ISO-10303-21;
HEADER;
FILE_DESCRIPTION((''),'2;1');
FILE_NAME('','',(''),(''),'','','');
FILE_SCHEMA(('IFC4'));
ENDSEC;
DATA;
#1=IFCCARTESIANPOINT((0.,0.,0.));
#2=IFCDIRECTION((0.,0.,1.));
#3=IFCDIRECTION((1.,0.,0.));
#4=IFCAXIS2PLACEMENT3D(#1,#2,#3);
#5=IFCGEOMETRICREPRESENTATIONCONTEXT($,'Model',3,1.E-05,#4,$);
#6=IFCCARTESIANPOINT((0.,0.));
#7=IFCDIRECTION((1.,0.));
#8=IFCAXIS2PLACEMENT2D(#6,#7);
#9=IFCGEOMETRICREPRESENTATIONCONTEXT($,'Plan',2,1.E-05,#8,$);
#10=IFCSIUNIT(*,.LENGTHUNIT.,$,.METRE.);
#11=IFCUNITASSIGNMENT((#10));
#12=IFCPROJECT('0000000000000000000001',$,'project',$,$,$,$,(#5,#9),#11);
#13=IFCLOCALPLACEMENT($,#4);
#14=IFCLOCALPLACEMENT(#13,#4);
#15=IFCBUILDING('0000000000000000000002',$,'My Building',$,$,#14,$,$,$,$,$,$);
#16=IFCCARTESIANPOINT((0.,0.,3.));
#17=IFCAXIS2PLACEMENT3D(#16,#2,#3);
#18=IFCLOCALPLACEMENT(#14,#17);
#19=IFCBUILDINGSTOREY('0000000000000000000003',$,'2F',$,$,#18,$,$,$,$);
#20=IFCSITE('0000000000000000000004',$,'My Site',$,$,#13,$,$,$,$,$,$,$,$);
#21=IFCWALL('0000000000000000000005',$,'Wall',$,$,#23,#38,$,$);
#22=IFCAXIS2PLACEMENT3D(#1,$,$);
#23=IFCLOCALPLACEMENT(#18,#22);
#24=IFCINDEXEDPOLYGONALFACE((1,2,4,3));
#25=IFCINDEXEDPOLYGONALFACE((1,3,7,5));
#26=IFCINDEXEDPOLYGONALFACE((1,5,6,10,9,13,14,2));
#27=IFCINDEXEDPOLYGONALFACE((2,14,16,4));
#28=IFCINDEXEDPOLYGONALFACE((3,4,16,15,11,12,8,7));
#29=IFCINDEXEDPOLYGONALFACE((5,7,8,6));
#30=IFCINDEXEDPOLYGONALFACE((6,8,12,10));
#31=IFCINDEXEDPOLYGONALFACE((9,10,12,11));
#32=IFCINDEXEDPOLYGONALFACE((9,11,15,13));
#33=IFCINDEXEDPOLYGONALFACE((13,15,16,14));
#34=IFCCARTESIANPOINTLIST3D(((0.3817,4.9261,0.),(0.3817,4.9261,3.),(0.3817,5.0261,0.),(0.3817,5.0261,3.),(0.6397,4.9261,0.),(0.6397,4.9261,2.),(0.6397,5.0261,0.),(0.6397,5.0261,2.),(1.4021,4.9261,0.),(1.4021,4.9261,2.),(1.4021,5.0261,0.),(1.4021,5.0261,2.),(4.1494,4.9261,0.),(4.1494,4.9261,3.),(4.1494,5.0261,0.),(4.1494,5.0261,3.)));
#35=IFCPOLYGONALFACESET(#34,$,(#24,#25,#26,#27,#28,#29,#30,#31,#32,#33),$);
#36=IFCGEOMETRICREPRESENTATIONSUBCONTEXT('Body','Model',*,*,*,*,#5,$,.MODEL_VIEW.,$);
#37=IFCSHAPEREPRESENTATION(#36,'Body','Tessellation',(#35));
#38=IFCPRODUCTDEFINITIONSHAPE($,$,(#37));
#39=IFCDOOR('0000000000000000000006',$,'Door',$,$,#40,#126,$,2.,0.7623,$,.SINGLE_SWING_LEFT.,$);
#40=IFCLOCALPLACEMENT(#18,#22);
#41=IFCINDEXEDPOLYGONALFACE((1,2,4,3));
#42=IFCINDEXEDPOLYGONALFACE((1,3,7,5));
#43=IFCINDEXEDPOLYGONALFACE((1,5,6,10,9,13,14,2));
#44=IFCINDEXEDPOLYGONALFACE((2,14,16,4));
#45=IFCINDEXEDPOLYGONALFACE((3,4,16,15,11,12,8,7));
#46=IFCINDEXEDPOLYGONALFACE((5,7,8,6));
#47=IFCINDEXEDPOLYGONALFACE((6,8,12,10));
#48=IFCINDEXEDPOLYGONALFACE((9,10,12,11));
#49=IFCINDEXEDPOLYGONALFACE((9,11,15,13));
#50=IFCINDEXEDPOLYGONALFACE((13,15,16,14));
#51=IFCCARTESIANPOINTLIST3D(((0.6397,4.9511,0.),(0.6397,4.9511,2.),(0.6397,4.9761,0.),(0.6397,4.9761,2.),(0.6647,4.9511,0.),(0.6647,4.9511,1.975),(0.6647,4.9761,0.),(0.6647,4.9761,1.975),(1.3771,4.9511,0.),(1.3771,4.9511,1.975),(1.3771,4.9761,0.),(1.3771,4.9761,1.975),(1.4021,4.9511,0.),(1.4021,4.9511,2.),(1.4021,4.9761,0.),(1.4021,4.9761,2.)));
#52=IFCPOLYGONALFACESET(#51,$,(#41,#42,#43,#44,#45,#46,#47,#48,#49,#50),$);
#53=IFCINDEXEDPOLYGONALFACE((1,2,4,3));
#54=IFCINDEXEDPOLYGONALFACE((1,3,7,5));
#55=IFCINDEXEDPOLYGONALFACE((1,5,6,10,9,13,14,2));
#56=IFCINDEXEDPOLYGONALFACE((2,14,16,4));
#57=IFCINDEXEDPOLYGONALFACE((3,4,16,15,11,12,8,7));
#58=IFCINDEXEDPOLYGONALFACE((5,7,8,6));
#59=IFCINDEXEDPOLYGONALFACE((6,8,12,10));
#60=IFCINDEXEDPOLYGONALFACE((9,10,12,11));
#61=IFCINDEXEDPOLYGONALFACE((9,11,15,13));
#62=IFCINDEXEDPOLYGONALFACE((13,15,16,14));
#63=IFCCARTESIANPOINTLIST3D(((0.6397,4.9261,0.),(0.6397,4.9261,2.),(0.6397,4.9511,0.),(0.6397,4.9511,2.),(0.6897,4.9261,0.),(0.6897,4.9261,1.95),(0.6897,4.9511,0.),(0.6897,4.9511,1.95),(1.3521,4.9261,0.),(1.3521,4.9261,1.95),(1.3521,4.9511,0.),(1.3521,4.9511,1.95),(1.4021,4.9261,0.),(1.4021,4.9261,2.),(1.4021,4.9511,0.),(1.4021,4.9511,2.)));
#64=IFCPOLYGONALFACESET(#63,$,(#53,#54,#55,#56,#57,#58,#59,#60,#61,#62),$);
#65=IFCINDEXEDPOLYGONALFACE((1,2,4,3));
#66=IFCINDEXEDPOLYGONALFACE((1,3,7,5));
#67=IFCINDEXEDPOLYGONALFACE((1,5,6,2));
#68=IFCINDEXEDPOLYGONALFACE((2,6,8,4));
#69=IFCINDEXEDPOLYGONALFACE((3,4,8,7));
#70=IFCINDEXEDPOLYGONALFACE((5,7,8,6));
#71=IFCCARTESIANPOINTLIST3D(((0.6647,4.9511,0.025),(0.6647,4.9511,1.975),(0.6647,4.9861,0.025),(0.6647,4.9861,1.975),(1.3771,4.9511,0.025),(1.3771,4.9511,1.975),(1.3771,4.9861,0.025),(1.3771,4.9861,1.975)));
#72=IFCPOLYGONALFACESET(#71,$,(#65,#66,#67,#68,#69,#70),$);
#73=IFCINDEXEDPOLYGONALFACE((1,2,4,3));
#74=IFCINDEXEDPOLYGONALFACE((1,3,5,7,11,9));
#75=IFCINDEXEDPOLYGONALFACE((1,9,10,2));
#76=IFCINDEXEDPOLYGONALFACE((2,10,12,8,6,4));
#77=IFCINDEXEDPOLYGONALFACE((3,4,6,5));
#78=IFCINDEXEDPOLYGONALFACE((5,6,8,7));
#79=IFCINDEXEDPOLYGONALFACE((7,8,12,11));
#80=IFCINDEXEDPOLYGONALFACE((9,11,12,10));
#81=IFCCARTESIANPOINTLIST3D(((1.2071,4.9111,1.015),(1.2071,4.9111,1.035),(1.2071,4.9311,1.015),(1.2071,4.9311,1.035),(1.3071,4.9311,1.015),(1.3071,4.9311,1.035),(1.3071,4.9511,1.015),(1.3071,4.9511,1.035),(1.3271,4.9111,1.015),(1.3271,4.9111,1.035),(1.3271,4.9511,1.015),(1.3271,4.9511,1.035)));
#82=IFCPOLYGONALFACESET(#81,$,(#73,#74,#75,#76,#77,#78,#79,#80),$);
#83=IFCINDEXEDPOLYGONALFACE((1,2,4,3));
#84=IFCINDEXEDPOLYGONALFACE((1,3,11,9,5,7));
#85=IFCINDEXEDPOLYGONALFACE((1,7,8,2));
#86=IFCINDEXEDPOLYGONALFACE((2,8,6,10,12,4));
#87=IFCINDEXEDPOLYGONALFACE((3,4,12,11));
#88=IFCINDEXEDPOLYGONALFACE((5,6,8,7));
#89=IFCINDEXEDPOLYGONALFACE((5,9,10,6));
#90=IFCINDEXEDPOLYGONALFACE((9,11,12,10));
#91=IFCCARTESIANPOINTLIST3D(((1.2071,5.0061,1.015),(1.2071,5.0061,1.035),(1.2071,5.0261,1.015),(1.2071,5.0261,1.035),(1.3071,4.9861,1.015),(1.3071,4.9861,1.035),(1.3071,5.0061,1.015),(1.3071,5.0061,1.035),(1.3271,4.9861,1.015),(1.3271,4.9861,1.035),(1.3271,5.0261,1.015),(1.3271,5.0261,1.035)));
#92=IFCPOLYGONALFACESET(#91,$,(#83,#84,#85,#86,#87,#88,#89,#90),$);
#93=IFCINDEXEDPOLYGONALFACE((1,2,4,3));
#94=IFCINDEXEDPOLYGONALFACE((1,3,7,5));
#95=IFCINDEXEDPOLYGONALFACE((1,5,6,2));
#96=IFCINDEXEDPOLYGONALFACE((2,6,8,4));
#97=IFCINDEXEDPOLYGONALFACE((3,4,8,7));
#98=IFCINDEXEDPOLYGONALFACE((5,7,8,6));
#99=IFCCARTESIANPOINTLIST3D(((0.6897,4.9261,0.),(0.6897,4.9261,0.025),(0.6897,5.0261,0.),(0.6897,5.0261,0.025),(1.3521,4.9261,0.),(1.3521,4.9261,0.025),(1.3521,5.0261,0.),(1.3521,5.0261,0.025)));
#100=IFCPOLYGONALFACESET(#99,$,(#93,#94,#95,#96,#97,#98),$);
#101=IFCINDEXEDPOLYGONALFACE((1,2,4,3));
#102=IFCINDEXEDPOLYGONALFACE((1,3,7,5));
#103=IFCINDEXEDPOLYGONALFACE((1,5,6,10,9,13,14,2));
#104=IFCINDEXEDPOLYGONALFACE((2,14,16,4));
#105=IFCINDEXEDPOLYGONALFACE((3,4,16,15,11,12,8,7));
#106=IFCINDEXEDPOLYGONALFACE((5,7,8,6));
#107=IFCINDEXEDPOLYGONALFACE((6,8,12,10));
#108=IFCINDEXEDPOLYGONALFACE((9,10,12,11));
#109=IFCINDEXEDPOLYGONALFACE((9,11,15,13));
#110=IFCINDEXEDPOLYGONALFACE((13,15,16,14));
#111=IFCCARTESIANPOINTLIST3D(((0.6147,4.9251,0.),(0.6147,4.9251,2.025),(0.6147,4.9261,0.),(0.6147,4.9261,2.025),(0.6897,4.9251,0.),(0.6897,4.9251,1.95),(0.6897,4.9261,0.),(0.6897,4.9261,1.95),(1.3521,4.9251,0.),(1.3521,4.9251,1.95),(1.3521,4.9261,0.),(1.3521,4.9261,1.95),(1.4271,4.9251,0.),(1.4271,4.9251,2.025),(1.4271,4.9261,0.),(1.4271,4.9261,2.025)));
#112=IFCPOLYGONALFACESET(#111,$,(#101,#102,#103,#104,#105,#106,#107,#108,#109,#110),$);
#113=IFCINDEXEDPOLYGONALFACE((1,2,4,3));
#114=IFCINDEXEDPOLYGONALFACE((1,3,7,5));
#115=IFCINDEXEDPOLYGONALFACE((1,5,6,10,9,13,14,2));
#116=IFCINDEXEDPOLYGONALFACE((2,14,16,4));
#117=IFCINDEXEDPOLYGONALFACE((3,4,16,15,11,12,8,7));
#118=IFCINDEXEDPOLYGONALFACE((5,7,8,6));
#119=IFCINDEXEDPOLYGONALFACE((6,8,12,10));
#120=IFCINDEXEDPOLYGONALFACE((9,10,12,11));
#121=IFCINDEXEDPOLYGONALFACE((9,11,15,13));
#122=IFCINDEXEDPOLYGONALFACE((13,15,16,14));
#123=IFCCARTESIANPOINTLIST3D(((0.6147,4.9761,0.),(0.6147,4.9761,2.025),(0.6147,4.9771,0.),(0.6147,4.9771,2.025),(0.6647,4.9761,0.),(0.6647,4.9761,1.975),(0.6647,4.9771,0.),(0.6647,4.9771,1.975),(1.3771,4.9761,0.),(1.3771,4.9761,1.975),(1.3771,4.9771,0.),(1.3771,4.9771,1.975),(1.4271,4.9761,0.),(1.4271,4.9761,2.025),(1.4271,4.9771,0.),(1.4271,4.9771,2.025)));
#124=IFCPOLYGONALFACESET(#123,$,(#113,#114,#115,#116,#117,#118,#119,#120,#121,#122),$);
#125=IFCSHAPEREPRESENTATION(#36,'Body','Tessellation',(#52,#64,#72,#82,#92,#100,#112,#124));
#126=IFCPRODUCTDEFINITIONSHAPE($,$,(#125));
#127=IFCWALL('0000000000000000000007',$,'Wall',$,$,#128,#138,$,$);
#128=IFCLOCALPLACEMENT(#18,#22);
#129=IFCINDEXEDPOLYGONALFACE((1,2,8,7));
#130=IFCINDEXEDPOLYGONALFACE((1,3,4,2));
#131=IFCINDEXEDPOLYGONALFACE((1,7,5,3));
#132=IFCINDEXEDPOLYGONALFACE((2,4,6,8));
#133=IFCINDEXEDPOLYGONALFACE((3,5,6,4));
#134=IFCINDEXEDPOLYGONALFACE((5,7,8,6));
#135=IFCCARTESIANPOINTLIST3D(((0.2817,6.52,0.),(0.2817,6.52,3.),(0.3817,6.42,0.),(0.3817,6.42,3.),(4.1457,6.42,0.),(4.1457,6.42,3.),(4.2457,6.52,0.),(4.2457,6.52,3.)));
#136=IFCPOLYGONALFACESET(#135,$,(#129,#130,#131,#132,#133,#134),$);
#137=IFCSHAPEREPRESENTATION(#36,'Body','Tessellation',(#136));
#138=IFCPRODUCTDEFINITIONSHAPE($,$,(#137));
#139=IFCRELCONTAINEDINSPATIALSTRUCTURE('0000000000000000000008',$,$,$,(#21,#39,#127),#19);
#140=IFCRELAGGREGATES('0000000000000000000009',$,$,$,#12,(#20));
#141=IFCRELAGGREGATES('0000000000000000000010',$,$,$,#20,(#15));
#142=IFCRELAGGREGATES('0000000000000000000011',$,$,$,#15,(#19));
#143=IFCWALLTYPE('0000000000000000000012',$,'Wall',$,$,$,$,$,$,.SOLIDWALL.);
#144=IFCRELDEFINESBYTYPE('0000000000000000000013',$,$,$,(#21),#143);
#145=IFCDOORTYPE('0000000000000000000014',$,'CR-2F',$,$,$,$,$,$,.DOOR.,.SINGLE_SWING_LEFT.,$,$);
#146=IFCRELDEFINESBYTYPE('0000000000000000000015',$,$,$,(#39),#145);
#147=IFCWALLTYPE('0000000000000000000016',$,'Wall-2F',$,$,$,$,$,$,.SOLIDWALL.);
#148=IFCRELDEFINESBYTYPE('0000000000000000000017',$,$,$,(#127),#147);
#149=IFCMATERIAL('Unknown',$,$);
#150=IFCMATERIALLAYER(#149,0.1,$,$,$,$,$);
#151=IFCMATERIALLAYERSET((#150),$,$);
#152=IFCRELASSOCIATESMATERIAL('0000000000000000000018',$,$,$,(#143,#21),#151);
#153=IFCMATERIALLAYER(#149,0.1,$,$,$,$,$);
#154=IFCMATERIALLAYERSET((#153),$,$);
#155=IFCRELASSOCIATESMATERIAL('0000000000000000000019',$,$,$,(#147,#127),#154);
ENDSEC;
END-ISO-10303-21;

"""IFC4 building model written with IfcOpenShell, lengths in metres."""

from ifc_helpers import new_model, entity, si_unit, frame, origin_with_axes, origin_2d_with_axis, place, context, subcontext, project, spatial, line, indexed_curve, outline, extrude, shape, source, transform, mapped, material, layer, layer_set, layer_usage, type_object, type_shapes, element, fill, save


model = new_model("IFC4")

# Units and contexts
model_context = context("Model", 3, precision=1e-05, world=origin_with_axes())
plan_context = context("Plan", 2, precision=1e-05, world=origin_2d_with_axis())
body_context_1 = subcontext(model_context, "Body", "Model", "MODEL_VIEW")
body_context_2 = subcontext(plan_context, "Body", "Plan", "PLAN_VIEW")
ifc_project = project(units=[si_unit("LENGTHUNIT", "METRE")], contexts=[model_context, plan_context])

# Site, building, storey
site_placement = place(None, origin_with_axes())
site = spatial("IfcSite", under=ifc_project, at=site_placement, Name="My Site")
building_placement = place(site_placement, origin_with_axes())
building = spatial("IfcBuilding", under=site, at=building_placement, Name="My Building")
storey_placement = place(building_placement, frame((0.0, 0.0, 3.0), z_axis=(0.0, 0.0, 1.0), x_axis=(1.0, 0.0, 0.0)))
storey = spatial("IfcBuildingStorey", under=building, at=storey_placement, Name="2F")

# Shared definitions
ifc_material = material(Name="Unknown")

# Shared definitions
ifc_layer_1 = layer(ifc_material, 0.1)
ifc_layer_set_1 = layer_set([ifc_layer_1])
wall_type_1 = type_object("IfcWallType", Name="Wall", PredefinedType="SOLIDWALL", material=ifc_layer_set_1)

# Wall, opening, door
ifc_layer_usage_1 = layer_usage(ifc_layer_set_1, "AXIS2", "POSITIVE", 0.0)
wall_1_placement = place(storey_placement, frame((4.1494, 5.0261, 0.0), z_axis=(0.0, 0.0, 1.0), x_axis=(-1.0, 0.0, 0.0)))
wall_1 = element("IfcWall", 1, at=wall_1_placement, inside=storey, type_object=wall_type_1, material=ifc_layer_usage_1, Name="Wall", context=body_context_1, shape_type="SweptSolid", body=[
    extrude(outline(indexed_curve([(0.0, 0.0), (0.0, 0.1), (3.7677, 0.1), (3.7677, 0.0)], segments=[line(1, 2, 3, 4, 1)])), origin_with_axes(), (0.0, 0.0, 1.0), 3.0),
])
shared_shape_1 = source(origin_with_axes(), body_context_1, "Body", "SweptSolid", [
    extrude(outline(indexed_curve([(0.0, 0.0), (0.7623, 0.0), (0.7623, 2.0), (0.0, 2.0)], segments=[line(1, 2, 3, 4, 1)])), frame((0.0, -0.6, 0.0), z_axis=(0.0, -1.0, 0.0), x_axis=(1.0, 0.0, 0.0)), (0.0, 0.0, -1.0), 1.2),
])
opening_1_placement = place(wall_1_placement, frame((3.5097, 0.1, 0.0), z_axis=(0.0, 0.0, 1.0), x_axis=(-1.0, 0.0, 0.0)))
opening_1 = element("IfcOpeningElement", 2, at=opening_1_placement, cuts=wall_1, PredefinedType="OPENING", context=body_context_1, shape_type="MappedRepresentation", body=[
    mapped(shared_shape_1, transform((0.0, 0.0, 0.0), x_axis=(1.0, 0.0, 0.0), y_axis=(0.0, 1.0, 0.0), z_axis=(0.0, 0.0, 1.0), scale=1.0)),
])
door_type_1 = type_object("IfcDoorType", Name="CR-2F", OperationType="SINGLE_SWING_LEFT", PredefinedType="DOOR")
shared_shape_2 = source(origin_with_axes(), body_context_1, "Body", "SweptSolid", [
    extrude(outline(indexed_curve([(0.0, 0.0), (0.0, 2.0), (0.7623, 2.0), (0.7623, 0.0), (0.7373, 0.0), (0.7373, 1.975), (0.025, 1.975), (0.025, 0.0)], segments=[line(1, 2, 3, 4, 5, 6, 7, 8, 1)])), frame((0.0, 0.025, 0.0), z_axis=(0.0, -1.0, 0.0), x_axis=(1.0, 0.0, 0.0)), (0.0, 0.0, -1.0), 0.025),
    extrude(outline(indexed_curve([(0.0, 0.0), (0.0, 2.0), (0.7623, 2.0), (0.7623, 0.0), (0.7123, 0.0), (0.7123, 1.95), (0.05, 1.95), (0.05, 0.0)], segments=[line(1, 2, 3, 4, 5, 6, 7, 8, 1)])), frame((0.0, 0.0, 0.0), z_axis=(0.0, -1.0, 0.0), x_axis=(1.0, 0.0, 0.0)), (0.0, 0.0, -1.0), 0.025),
    extrude(outline(indexed_curve([(0.0, 0.0), (0.7123, 0.0), (0.7123, 0.035), (0.0, 0.035)], segments=[line(1, 2, 3, 4, 1)])), frame((0.025, 0.025, 0.025), z_axis=(0.0, 0.0, 1.0), x_axis=(1.0, 0.0, 0.0)), (0.0, 0.0, 1.0), 1.95),
    extrude(outline(indexed_curve([(0.0, 0.0), (0.0, -0.04), (-0.12, -0.04), (-0.12, -0.02), (-0.02, -0.02), (-0.02, 0.0)], segments=[line(1, 2, 3, 4, 5, 6, 1)])), frame((0.6873, 0.025, 1.015), z_axis=(0.0, 0.0, 1.0), x_axis=(1.0, 0.0, 0.0)), (0.0, 0.0, 1.0), 0.02),
    extrude(outline(indexed_curve([(0.0, 0.0), (0.0, 0.04), (-0.12, 0.04), (-0.12, 0.02), (-0.02, 0.02), (-0.02, 0.0)], segments=[line(1, 2, 3, 4, 5, 6, 1)])), frame((0.6873, 0.06, 1.015), z_axis=(0.0, 0.0, 1.0), x_axis=(1.0, 0.0, 0.0)), (0.0, 0.0, 1.0), 0.02),
    extrude(outline(indexed_curve([(0.0, 0.0), (0.6623, 0.0), (0.6623, 0.1), (0.0, 0.1)], segments=[line(1, 2, 3, 4, 1)])), frame((0.05, 0.0, 0.0), z_axis=(0.0, 0.0, 1.0), x_axis=(1.0, 0.0, 0.0)), (0.0, 0.0, 1.0), 0.025),
    extrude(outline(indexed_curve([(0.0, 0.0), (0.0, 2.025), (0.8123, 2.025), (0.8123, 0.0), (0.7373, 0.0), (0.7373, 1.95), (0.075, 1.95), (0.075, 0.0)], segments=[line(1, 2, 3, 4, 5, 6, 7, 8, 1)])), frame((-0.025, -0.001, 0.0), z_axis=(0.0, -1.0, 0.0), x_axis=(1.0, 0.0, 0.0)), (0.0, 0.0, -1.0), 0.001),
    extrude(outline(indexed_curve([(0.0, 0.0), (0.0, 2.025), (0.8123, 2.025), (0.8123, 0.0), (0.7623, 0.0), (0.7623, 1.975), (0.05, 1.975), (0.05, 0.0)], segments=[line(1, 2, 3, 4, 5, 6, 7, 8, 1)])), frame((-0.025, 0.05, 0.0), z_axis=(0.0, -1.0, 0.0), x_axis=(1.0, 0.0, 0.0)), (0.0, 0.0, -1.0), 0.001),
])
shared_shape_3 = source(origin_with_axes(), body_context_2, "Body", "Curve2D", [
    entity("IfcIndexedPolyCurve", entity("IfcCartesianPointList2D", [[0.0, 0.0], [0.0, 0.05], [0.025, 0.05], [0.025, 0.025], [0.05, 0.025], [0.05, 0.0]]), [entity("IfcLineIndex", [1, 2, 3, 4, 5, 6, 1])]),
    entity("IfcIndexedPolyCurve", entity("IfcCartesianPointList2D", [[0.7623, 0.0], [0.7623, 0.05], [0.7373, 0.05], [0.7373, 0.025], [0.7123, 0.025], [0.7123, 0.0]]), [entity("IfcLineIndex", [1, 2, 3, 4, 5, 6, 1])]),
    entity("IfcTrimmedCurve", entity("IfcEllipse", entity("IfcAxis2Placement2D", entity("IfcCartesianPoint", [0.06, 0.05]), entity("IfcDirection", [1.0, 0.0])), 0.6773, 0.7123), [entity("IfcCartesianPoint", [0.7373, 0.05])], [entity("IfcCartesianPoint", [0.06, 0.7623])], True, "CARTESIAN"),
    entity("IfcIndexedPolyCurve", entity("IfcCartesianPointList2D", [[0.025, 0.05], [0.06, 0.05], [0.06, 0.7623], [0.025, 0.7623]]), [entity("IfcLineIndex", [1, 2, 3, 4, 1])]),
])
type_shapes(door_type_1, [shared_shape_2, shared_shape_3])
door_1_placement = place(opening_1_placement, frame((0.0, 0.0, 0.0), z_axis=(0.0, 0.0, 1.0), x_axis=(1.0, 0.0, 0.0)))
door_1 = element("IfcDoor", 3, at=door_1_placement, inside=storey, type_object=door_type_1, Name="Door", OperationType="SINGLE_SWING_LEFT", OverallHeight=2.0, OverallWidth=0.7623, shapes=[
    shape(body_context_1, "Body", "MappedRepresentation", [mapped(shared_shape_2, transform((0.0, 0.0, 0.0), x_axis=(1.0, 0.0, 0.0), y_axis=(0.0, 1.0, 0.0), z_axis=(0.0, 0.0, 1.0), scale=1.0))]),
    shape(body_context_2, "Body", "MappedRepresentation", [mapped(shared_shape_3, transform((0.0, 0.0, 0.0), x_axis=(1.0, 0.0, 0.0), y_axis=(0.0, 1.0, 0.0), z_axis=(0.0, 0.0, 1.0), scale=1.0))]),
])
fill(opening_1, door_1)

# Wall
ifc_layer_2 = layer(ifc_material, 0.1)
ifc_layer_set_2 = layer_set([ifc_layer_2])
ifc_layer_usage_2 = layer_usage(ifc_layer_set_2, "AXIS2", "POSITIVE", 0.0)
wall_type_2 = type_object("IfcWallType", Name="Wall-2F", PredefinedType="SOLIDWALL", material=ifc_layer_set_2)
wall_2_placement = place(storey_placement, frame((4.2457, 6.52, 0.0), z_axis=(0.0, 0.0, 1.0), x_axis=(-1.0, 0.0, 0.0)))
element("IfcWall", 4, at=wall_2_placement, inside=storey, type_object=wall_type_2, material=ifc_layer_usage_2, Name="Wall", context=body_context_1, shape_type="SweptSolid", body=[
    extrude(outline(indexed_curve([(0.0, 0.0), (0.1, 0.1), (3.864, 0.1), (3.964, 0.0)], segments=[line(1, 2, 3, 4, 1)])), origin_with_axes(), (0.0, 0.0, 1.0), 3.0),
])

save(model, "model.ifc")
